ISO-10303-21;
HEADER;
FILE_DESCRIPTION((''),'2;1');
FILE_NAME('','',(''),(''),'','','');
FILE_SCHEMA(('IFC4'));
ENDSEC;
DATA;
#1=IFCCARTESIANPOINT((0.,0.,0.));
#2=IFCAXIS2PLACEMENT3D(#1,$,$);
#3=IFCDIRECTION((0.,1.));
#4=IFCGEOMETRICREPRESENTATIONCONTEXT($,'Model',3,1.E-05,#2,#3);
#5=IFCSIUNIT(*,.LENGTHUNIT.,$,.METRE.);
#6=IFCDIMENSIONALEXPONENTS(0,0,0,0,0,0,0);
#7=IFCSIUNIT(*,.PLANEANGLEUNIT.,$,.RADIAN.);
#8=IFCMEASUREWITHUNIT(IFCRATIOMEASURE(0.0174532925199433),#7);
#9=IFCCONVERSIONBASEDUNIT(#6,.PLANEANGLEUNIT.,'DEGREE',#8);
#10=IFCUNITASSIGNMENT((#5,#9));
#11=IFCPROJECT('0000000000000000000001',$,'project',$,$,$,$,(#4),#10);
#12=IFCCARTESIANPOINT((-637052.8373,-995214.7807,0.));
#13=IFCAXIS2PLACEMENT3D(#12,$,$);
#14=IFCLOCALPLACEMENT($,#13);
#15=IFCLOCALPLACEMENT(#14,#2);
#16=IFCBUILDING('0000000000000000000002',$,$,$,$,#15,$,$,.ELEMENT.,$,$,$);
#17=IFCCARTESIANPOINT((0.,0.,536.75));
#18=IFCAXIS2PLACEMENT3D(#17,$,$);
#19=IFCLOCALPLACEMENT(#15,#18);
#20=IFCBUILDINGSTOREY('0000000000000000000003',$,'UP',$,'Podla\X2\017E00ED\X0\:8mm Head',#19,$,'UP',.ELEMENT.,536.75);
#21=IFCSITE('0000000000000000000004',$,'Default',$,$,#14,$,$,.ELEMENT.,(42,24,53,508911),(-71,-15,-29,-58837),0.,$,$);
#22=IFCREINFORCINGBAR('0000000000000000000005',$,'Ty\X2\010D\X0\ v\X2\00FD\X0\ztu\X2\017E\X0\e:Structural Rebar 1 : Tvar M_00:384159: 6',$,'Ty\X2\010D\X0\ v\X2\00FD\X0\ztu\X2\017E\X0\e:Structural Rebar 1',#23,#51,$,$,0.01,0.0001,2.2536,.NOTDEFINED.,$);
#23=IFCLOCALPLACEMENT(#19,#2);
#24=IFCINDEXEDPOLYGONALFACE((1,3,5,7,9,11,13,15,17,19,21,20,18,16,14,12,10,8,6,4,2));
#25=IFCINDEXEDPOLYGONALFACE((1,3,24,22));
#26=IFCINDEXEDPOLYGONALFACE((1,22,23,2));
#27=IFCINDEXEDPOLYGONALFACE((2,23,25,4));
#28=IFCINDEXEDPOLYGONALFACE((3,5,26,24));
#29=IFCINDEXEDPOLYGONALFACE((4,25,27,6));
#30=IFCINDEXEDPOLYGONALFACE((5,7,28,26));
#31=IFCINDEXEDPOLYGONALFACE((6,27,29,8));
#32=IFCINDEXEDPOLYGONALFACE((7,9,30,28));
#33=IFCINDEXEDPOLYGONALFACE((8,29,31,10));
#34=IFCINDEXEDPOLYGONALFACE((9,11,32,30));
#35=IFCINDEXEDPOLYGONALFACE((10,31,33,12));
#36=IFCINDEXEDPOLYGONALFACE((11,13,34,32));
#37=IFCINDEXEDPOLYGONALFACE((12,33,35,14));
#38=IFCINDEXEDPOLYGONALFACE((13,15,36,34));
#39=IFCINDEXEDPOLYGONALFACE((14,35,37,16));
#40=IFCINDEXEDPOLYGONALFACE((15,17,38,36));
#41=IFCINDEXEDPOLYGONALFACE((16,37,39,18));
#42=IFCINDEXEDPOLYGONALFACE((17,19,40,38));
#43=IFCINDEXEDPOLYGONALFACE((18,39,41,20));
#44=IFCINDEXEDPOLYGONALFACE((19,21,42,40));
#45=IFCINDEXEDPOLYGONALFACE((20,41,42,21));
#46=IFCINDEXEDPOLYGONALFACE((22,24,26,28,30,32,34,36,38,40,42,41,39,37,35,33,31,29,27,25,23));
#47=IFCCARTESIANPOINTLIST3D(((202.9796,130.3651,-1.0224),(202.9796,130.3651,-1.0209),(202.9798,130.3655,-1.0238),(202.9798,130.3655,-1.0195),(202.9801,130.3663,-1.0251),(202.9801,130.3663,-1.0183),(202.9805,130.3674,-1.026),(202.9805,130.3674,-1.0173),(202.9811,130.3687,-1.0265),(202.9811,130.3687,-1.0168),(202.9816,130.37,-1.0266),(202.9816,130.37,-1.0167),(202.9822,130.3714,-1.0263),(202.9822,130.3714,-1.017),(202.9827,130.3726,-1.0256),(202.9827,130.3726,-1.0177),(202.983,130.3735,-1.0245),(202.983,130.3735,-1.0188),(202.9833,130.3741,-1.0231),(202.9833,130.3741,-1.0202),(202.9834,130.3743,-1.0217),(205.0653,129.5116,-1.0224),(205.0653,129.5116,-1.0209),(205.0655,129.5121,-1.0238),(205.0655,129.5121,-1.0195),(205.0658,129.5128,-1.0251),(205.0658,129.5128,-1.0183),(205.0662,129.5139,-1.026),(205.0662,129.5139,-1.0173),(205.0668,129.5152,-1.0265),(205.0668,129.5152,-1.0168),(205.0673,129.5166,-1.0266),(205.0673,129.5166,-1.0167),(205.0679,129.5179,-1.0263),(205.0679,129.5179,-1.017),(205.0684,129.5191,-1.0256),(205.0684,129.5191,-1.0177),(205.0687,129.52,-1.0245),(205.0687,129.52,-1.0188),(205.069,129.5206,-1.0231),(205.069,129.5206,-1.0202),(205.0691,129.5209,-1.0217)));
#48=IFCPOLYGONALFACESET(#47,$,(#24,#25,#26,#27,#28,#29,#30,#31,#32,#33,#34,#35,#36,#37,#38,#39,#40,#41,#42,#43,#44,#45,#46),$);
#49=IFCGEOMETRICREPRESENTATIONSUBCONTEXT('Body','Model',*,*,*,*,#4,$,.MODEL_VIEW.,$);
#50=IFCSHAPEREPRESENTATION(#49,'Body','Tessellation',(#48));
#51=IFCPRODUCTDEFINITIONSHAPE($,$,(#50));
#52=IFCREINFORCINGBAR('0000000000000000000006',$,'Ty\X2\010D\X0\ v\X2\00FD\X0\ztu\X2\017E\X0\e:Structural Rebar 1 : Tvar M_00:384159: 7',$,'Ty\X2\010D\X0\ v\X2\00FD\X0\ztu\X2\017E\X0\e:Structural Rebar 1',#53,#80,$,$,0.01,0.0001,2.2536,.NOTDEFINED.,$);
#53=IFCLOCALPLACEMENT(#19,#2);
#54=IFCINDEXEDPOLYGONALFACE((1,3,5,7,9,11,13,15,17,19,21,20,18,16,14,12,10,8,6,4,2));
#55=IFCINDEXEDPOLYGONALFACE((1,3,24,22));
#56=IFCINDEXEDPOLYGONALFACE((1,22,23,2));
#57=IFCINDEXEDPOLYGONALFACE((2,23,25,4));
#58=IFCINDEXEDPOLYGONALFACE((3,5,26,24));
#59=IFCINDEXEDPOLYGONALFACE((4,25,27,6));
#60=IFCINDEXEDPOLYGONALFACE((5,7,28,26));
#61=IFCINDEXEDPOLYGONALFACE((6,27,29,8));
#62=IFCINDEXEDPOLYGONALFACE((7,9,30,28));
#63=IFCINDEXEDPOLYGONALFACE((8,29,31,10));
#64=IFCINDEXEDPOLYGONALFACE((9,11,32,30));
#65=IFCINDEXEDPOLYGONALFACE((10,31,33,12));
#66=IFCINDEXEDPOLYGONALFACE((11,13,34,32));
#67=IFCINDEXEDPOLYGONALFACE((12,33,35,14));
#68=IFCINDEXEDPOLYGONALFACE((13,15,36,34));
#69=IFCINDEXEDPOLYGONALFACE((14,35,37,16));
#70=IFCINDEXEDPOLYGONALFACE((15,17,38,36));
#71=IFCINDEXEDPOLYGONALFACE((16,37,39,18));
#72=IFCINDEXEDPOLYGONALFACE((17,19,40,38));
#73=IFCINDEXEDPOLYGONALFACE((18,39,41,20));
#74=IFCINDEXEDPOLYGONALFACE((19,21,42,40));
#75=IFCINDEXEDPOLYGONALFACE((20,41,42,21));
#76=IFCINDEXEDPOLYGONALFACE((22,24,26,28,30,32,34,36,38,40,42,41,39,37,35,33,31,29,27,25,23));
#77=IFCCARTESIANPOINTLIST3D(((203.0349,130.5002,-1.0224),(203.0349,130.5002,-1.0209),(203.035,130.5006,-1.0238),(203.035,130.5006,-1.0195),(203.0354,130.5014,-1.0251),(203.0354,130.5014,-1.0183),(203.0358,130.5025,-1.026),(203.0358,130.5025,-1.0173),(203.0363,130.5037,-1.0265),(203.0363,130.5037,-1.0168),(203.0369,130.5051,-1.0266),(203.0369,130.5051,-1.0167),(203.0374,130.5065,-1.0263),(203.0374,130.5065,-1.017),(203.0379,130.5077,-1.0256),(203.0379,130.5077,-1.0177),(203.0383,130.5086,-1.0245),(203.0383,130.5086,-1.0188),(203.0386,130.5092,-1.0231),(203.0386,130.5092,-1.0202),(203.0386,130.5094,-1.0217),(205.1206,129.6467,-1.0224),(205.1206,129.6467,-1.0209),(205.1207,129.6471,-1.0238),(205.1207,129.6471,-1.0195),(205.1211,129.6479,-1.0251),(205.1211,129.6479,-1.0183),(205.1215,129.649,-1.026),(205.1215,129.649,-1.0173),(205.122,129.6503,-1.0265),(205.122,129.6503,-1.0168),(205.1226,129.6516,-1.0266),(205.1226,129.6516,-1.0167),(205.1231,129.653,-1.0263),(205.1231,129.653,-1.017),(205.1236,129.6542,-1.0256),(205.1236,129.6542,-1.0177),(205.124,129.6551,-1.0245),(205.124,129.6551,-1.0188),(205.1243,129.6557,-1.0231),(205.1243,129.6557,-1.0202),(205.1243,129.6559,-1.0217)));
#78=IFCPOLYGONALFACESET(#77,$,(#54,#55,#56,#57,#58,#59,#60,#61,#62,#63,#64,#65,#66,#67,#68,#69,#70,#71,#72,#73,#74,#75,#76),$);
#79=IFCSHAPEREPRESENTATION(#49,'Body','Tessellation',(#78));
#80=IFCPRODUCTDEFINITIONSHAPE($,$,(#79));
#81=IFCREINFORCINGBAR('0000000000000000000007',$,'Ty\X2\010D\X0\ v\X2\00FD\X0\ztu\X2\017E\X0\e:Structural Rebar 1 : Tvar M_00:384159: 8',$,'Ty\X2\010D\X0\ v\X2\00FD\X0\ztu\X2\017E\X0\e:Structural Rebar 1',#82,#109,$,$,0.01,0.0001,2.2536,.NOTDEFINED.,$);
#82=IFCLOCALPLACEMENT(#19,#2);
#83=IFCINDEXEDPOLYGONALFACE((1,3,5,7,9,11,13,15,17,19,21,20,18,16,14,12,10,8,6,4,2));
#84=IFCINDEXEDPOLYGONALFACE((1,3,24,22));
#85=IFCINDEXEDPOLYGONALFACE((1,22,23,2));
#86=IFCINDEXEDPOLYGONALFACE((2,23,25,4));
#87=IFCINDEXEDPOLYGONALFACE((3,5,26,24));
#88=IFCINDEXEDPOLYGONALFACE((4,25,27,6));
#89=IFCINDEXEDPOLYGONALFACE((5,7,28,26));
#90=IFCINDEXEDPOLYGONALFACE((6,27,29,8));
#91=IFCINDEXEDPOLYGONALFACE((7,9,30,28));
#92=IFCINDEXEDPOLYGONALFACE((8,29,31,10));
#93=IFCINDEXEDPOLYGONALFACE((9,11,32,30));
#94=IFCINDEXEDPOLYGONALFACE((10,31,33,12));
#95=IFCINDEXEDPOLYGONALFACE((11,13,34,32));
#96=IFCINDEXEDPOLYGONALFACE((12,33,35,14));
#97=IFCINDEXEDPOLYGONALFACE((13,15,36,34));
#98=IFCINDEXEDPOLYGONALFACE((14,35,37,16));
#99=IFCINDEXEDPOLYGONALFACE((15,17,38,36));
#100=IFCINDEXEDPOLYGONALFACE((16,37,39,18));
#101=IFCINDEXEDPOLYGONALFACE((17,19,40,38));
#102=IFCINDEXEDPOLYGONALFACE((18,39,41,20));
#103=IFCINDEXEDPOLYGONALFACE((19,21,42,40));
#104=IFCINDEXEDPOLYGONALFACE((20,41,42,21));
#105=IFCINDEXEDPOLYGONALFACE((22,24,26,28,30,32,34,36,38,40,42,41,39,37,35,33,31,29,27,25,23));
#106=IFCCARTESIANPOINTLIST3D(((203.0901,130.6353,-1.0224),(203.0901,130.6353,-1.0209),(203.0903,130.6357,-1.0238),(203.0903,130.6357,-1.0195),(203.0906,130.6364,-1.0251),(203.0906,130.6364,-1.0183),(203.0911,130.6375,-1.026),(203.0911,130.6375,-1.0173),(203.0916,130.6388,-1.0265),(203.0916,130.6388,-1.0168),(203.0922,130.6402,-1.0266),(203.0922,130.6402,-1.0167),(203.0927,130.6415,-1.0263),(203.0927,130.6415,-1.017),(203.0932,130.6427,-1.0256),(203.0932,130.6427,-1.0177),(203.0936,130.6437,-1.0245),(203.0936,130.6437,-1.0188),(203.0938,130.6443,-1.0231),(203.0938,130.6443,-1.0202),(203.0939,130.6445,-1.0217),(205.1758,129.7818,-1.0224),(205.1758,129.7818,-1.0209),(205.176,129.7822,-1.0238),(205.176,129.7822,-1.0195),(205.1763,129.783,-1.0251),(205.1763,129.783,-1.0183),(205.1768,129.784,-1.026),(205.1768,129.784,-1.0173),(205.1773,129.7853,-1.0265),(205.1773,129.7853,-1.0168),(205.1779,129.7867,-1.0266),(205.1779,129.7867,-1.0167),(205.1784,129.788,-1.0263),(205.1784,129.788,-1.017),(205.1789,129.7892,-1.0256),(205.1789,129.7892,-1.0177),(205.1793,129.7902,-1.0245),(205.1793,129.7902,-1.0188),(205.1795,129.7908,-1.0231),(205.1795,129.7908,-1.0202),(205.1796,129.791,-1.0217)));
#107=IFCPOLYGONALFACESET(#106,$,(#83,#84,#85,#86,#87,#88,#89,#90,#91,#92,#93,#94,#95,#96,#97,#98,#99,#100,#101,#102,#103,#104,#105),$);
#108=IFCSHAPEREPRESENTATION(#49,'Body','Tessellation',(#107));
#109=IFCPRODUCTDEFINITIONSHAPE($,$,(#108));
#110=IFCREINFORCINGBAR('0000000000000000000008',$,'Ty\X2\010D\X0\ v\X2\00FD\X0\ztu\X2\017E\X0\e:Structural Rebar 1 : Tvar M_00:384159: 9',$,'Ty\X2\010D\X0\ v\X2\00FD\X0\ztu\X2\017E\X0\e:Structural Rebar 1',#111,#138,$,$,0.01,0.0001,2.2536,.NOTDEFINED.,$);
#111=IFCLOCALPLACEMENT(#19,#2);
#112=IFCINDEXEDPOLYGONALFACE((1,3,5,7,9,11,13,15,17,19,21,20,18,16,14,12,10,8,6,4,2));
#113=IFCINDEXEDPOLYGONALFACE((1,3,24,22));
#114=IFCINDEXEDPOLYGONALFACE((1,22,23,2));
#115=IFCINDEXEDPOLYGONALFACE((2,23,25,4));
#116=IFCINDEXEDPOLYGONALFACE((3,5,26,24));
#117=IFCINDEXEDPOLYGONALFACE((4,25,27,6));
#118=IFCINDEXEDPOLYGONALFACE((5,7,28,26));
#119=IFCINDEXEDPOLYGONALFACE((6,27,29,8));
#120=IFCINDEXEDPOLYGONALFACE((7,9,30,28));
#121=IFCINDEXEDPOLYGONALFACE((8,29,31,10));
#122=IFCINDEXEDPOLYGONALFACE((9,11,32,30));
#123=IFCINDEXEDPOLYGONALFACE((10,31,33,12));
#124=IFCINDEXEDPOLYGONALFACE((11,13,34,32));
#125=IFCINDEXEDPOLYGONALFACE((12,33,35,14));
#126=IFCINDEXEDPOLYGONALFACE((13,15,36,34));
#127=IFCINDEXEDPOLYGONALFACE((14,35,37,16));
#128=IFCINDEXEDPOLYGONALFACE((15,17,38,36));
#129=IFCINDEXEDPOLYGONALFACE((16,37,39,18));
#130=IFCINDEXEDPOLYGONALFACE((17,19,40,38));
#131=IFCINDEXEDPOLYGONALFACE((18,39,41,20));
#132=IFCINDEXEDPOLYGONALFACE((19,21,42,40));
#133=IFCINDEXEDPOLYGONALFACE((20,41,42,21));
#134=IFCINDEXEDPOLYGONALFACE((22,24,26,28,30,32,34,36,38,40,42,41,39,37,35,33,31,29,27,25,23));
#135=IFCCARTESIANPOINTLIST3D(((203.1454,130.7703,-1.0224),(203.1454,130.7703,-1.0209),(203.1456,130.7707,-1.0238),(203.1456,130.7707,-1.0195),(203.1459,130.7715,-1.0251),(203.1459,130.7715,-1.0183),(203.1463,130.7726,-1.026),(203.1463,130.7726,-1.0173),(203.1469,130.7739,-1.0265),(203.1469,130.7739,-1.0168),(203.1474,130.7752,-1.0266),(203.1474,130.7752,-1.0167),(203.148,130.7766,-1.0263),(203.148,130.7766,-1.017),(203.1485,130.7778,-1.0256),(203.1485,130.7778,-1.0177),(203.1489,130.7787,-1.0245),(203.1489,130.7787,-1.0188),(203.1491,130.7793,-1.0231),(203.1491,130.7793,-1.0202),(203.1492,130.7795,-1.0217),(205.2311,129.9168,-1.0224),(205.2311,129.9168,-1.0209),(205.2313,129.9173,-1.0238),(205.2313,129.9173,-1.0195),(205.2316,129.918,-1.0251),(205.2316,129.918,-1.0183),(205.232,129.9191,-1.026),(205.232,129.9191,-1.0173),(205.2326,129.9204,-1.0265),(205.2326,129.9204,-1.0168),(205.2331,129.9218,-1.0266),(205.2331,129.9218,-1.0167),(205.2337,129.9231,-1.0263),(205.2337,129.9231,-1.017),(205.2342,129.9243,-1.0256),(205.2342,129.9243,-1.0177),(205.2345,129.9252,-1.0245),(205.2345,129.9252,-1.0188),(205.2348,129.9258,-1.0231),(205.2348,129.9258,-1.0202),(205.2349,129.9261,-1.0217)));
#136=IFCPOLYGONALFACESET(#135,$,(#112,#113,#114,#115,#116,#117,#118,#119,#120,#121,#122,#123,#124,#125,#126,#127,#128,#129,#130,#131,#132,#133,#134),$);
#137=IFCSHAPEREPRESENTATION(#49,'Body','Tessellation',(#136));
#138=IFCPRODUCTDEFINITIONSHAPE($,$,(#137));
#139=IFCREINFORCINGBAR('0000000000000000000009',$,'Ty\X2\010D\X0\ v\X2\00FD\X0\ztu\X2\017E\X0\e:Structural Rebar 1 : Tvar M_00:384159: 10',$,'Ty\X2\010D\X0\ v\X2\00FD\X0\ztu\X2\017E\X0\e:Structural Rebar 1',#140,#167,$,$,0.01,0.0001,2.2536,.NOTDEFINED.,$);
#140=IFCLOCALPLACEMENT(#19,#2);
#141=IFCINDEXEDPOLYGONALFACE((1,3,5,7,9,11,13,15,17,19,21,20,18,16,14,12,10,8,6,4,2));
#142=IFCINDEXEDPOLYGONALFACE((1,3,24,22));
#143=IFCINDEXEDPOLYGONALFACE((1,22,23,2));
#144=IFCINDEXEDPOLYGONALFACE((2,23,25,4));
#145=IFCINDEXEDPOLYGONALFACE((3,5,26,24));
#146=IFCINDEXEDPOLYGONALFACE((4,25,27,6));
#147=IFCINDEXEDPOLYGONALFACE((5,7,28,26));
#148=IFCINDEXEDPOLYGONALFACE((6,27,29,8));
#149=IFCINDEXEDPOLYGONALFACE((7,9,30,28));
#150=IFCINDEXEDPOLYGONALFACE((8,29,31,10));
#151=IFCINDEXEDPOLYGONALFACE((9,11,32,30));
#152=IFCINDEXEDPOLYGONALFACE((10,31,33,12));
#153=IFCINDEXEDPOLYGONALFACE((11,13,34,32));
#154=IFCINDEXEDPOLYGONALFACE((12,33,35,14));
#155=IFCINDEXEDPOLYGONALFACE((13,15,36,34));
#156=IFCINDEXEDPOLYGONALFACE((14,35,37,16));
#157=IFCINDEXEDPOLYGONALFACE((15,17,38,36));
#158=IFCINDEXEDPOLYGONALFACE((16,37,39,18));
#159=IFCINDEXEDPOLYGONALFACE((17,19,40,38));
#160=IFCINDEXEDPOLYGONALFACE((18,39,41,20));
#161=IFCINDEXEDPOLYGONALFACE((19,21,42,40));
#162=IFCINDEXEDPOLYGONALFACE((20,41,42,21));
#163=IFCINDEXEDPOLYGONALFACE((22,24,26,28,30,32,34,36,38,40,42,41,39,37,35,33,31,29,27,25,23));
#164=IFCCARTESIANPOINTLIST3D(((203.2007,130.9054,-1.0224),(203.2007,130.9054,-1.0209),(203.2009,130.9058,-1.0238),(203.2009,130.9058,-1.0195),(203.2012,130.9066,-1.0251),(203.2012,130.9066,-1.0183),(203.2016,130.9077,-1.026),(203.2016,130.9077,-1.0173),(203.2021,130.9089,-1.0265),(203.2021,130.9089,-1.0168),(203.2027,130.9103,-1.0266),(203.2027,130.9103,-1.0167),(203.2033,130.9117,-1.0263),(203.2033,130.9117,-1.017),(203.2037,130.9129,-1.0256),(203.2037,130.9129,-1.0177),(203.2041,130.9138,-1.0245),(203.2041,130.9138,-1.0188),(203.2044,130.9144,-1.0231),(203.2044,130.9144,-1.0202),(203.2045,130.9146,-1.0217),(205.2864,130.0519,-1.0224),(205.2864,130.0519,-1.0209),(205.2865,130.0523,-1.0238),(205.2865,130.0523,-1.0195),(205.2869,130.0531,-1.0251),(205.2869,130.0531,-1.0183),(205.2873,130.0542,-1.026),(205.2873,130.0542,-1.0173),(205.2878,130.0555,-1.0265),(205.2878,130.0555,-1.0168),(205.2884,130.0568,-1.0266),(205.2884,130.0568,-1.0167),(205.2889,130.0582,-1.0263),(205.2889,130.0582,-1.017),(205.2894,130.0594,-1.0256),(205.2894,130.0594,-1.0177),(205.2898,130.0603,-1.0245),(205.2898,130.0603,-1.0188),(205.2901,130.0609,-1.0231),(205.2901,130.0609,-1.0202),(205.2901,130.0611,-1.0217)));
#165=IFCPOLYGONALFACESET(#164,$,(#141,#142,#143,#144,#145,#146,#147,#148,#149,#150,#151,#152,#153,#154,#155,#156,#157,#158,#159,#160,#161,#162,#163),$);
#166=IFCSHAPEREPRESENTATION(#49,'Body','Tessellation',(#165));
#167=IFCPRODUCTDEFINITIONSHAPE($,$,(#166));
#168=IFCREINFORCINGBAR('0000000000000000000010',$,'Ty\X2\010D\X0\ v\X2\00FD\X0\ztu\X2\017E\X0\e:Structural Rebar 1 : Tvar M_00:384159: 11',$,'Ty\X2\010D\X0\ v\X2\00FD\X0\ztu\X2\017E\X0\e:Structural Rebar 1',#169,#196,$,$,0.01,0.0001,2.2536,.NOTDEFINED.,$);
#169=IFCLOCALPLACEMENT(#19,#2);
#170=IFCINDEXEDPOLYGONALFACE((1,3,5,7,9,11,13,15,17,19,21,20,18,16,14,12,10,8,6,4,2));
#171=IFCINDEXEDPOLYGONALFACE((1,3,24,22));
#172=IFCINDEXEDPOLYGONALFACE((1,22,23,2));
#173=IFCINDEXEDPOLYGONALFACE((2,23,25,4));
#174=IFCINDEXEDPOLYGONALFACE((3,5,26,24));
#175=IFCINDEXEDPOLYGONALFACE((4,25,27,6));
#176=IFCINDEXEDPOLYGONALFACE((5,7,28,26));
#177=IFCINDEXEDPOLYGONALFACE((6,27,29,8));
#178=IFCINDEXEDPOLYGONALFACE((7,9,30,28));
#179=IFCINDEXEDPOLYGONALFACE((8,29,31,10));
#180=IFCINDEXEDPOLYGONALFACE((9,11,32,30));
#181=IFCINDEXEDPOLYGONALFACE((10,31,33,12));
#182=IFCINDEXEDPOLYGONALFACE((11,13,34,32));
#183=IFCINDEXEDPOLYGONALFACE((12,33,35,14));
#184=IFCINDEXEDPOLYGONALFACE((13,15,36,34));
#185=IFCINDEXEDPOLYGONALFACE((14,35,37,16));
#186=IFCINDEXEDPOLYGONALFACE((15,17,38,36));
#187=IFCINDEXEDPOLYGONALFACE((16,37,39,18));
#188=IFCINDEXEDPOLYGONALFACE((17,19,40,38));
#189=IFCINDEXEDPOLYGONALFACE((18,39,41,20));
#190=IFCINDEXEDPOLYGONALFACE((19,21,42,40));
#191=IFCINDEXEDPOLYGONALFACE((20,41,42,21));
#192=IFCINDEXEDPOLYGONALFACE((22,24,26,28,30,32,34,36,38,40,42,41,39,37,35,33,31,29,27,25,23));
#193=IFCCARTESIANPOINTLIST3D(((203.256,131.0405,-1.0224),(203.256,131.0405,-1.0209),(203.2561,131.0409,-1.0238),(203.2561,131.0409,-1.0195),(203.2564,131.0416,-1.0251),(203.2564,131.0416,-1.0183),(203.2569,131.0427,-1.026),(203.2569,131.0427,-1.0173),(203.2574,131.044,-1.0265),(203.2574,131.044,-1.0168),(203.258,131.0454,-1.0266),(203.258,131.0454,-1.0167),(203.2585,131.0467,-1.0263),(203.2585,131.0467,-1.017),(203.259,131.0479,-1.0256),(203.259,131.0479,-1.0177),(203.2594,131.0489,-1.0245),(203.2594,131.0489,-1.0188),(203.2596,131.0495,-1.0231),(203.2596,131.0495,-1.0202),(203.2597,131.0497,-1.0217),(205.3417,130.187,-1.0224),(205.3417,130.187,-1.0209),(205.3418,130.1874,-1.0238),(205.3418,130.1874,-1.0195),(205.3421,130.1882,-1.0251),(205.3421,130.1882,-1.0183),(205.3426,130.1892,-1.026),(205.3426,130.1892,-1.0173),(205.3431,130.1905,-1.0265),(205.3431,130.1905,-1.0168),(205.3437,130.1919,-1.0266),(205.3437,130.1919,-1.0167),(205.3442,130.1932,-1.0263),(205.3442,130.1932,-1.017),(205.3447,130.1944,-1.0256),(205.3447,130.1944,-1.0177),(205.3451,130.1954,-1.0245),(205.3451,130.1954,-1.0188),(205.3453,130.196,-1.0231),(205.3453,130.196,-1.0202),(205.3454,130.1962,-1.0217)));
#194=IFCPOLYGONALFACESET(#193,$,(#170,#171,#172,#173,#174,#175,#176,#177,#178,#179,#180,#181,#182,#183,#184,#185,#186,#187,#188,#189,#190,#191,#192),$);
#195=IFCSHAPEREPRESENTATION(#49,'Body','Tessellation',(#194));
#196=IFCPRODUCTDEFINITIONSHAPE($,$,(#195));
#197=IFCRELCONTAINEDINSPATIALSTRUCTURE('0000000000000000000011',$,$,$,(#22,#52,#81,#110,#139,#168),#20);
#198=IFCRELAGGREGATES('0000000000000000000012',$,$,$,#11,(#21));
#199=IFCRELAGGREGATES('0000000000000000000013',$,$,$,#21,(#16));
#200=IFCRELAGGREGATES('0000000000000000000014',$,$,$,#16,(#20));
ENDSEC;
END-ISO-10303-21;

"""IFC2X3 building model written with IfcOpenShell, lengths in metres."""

from ifc_helpers import new_model, entity, si_unit, converted_unit, direction, frame, origin, place, context, subcontext, project, spatial, element, save


model = new_model("IFC2X3")

# Units and contexts
model_context = context("Model", 3, precision=1e-05, world=origin(), true_north=direction((0.0, 1.0)))
body_context = subcontext(model_context, "Body", "Model", "MODEL_VIEW")
ifc_project = project(units=[si_unit("LENGTHUNIT", "METRE"), converted_unit("PLANEANGLEUNIT", "DEGREE", entity("IfcRatioMeasure", 0.0174532925199433), si_unit("PLANEANGLEUNIT", "RADIAN"), dimensions=[0, 0, 0, 0, 0, 0, 0])], contexts=[model_context])

# Site, building, storey
site_placement = place(None, frame((-637052.8373, -995214.7807, 0.0)))
site = spatial("IfcSite", under=ifc_project, at=site_placement, Name="Default", CompositionType="ELEMENT", RefLatitude=(42, 24, 53, 508911), RefLongitude=(-71, -15, -29, -58837), RefElevation=0.0)
building_placement = place(site_placement, origin())
building = spatial("IfcBuilding", under=site, at=building_placement, CompositionType="ELEMENT")
storey_placement = place(building_placement, frame((0.0, 0.0, 536.75)))
storey = spatial("IfcBuildingStorey", under=building, at=storey_placement, Name="UP", ObjectType="Podlaží:8mm Head", LongName="UP", CompositionType="ELEMENT", Elevation=536.75)

# Reinforcing bars
reinforcing_bar_1_placement = place(storey_placement, origin())
element("IfcReinforcingBar", 1, at=reinforcing_bar_1_placement, inside=storey, Name="Tyč výztuže:Structural Rebar 1 : Tvar M_00:384159: 6", ObjectType="Tyč výztuže:Structural Rebar 1", BarLength=2.2536, BarRole="NOTDEFINED", CrossSectionArea=0.0001, NominalDiameter=0.01, context=body_context, shape_type="AdvancedSweptSolid", body=[
    entity("IfcSweptDiskSolid", entity("IfcCompositeCurve", [entity("IfcCompositeCurveSegment", "CONTINUOUS", True, entity("IfcPolyline", [entity("IfcCartesianPoint", [-205.0672, -129.5162, 1.0217]), entity("IfcCartesianPoint", [-202.9815, -130.3697, 1.0217])]))], False), 0.005, None, 0.0, 1.0),
])
reinforcing_bar_2_placement = place(storey_placement, origin())
element("IfcReinforcingBar", 2, at=reinforcing_bar_2_placement, inside=storey, Name="Tyč výztuže:Structural Rebar 1 : Tvar M_00:384159: 7", ObjectType="Tyč výztuže:Structural Rebar 1", BarLength=2.2536, BarRole="NOTDEFINED", CrossSectionArea=0.0001, NominalDiameter=0.01, context=body_context, shape_type="AdvancedSweptSolid", body=[
    entity("IfcSweptDiskSolid", entity("IfcCompositeCurve", [entity("IfcCompositeCurveSegment", "CONTINUOUS", True, entity("IfcPolyline", [entity("IfcCartesianPoint", [-205.1224, -129.6513, 1.0217]), entity("IfcCartesianPoint", [-203.0367, -130.5048, 1.0217])]))], False), 0.005, None, 0.0, 1.0),
])
reinforcing_bar_3_placement = place(storey_placement, origin())
element("IfcReinforcingBar", 3, at=reinforcing_bar_3_placement, inside=storey, Name="Tyč výztuže:Structural Rebar 1 : Tvar M_00:384159: 8", ObjectType="Tyč výztuže:Structural Rebar 1", BarLength=2.2536, BarRole="NOTDEFINED", CrossSectionArea=0.0001, NominalDiameter=0.01, context=body_context, shape_type="AdvancedSweptSolid", body=[
    entity("IfcSweptDiskSolid", entity("IfcCompositeCurve", [entity("IfcCompositeCurveSegment", "CONTINUOUS", True, entity("IfcPolyline", [entity("IfcCartesianPoint", [-205.1777, -129.7864, 1.0217]), entity("IfcCartesianPoint", [-203.092, -130.6398, 1.0217])]))], False), 0.005, None, 0.0, 1.0),
])
reinforcing_bar_4_placement = place(storey_placement, origin())
element("IfcReinforcingBar", 4, at=reinforcing_bar_4_placement, inside=storey, Name="Tyč výztuže:Structural Rebar 1 : Tvar M_00:384159: 9", ObjectType="Tyč výztuže:Structural Rebar 1", BarLength=2.2536, BarRole="NOTDEFINED", CrossSectionArea=0.0001, NominalDiameter=0.01, context=body_context, shape_type="AdvancedSweptSolid", body=[
    entity("IfcSweptDiskSolid", entity("IfcCompositeCurve", [entity("IfcCompositeCurveSegment", "CONTINUOUS", True, entity("IfcPolyline", [entity("IfcCartesianPoint", [-205.233, -129.9214, 1.0217]), entity("IfcCartesianPoint", [-203.1473, -130.7749, 1.0217])]))], False), 0.005, None, 0.0, 1.0),
])
reinforcing_bar_5_placement = place(storey_placement, origin())
element("IfcReinforcingBar", 5, at=reinforcing_bar_5_placement, inside=storey, Name="Tyč výztuže:Structural Rebar 1 : Tvar M_00:384159: 10", ObjectType="Tyč výztuže:Structural Rebar 1", BarLength=2.2536, BarRole="NOTDEFINED", CrossSectionArea=0.0001, NominalDiameter=0.01, context=body_context, shape_type="AdvancedSweptSolid", body=[
    entity("IfcSweptDiskSolid", entity("IfcCompositeCurve", [entity("IfcCompositeCurveSegment", "CONTINUOUS", True, entity("IfcPolyline", [entity("IfcCartesianPoint", [-205.2883, -130.0565, 1.0217]), entity("IfcCartesianPoint", [-203.2026, -130.91, 1.0217])]))], False), 0.005, None, 0.0, 1.0),
])
reinforcing_bar_6_placement = place(storey_placement, origin())
element("IfcReinforcingBar", 6, at=reinforcing_bar_6_placement, inside=storey, Name="Tyč výztuže:Structural Rebar 1 : Tvar M_00:384159: 11", ObjectType="Tyč výztuže:Structural Rebar 1", BarLength=2.2536, BarRole="NOTDEFINED", CrossSectionArea=0.0001, NominalDiameter=0.01, context=body_context, shape_type="AdvancedSweptSolid", body=[
    entity("IfcSweptDiskSolid", entity("IfcCompositeCurve", [entity("IfcCompositeCurveSegment", "CONTINUOUS", True, entity("IfcPolyline", [entity("IfcCartesianPoint", [-205.3435, -130.1916, 1.0217]), entity("IfcCartesianPoint", [-203.2578, -131.045, 1.0217])]))], False), 0.005, None, 0.0, 1.0),
])

save(model, "model.ifc")
